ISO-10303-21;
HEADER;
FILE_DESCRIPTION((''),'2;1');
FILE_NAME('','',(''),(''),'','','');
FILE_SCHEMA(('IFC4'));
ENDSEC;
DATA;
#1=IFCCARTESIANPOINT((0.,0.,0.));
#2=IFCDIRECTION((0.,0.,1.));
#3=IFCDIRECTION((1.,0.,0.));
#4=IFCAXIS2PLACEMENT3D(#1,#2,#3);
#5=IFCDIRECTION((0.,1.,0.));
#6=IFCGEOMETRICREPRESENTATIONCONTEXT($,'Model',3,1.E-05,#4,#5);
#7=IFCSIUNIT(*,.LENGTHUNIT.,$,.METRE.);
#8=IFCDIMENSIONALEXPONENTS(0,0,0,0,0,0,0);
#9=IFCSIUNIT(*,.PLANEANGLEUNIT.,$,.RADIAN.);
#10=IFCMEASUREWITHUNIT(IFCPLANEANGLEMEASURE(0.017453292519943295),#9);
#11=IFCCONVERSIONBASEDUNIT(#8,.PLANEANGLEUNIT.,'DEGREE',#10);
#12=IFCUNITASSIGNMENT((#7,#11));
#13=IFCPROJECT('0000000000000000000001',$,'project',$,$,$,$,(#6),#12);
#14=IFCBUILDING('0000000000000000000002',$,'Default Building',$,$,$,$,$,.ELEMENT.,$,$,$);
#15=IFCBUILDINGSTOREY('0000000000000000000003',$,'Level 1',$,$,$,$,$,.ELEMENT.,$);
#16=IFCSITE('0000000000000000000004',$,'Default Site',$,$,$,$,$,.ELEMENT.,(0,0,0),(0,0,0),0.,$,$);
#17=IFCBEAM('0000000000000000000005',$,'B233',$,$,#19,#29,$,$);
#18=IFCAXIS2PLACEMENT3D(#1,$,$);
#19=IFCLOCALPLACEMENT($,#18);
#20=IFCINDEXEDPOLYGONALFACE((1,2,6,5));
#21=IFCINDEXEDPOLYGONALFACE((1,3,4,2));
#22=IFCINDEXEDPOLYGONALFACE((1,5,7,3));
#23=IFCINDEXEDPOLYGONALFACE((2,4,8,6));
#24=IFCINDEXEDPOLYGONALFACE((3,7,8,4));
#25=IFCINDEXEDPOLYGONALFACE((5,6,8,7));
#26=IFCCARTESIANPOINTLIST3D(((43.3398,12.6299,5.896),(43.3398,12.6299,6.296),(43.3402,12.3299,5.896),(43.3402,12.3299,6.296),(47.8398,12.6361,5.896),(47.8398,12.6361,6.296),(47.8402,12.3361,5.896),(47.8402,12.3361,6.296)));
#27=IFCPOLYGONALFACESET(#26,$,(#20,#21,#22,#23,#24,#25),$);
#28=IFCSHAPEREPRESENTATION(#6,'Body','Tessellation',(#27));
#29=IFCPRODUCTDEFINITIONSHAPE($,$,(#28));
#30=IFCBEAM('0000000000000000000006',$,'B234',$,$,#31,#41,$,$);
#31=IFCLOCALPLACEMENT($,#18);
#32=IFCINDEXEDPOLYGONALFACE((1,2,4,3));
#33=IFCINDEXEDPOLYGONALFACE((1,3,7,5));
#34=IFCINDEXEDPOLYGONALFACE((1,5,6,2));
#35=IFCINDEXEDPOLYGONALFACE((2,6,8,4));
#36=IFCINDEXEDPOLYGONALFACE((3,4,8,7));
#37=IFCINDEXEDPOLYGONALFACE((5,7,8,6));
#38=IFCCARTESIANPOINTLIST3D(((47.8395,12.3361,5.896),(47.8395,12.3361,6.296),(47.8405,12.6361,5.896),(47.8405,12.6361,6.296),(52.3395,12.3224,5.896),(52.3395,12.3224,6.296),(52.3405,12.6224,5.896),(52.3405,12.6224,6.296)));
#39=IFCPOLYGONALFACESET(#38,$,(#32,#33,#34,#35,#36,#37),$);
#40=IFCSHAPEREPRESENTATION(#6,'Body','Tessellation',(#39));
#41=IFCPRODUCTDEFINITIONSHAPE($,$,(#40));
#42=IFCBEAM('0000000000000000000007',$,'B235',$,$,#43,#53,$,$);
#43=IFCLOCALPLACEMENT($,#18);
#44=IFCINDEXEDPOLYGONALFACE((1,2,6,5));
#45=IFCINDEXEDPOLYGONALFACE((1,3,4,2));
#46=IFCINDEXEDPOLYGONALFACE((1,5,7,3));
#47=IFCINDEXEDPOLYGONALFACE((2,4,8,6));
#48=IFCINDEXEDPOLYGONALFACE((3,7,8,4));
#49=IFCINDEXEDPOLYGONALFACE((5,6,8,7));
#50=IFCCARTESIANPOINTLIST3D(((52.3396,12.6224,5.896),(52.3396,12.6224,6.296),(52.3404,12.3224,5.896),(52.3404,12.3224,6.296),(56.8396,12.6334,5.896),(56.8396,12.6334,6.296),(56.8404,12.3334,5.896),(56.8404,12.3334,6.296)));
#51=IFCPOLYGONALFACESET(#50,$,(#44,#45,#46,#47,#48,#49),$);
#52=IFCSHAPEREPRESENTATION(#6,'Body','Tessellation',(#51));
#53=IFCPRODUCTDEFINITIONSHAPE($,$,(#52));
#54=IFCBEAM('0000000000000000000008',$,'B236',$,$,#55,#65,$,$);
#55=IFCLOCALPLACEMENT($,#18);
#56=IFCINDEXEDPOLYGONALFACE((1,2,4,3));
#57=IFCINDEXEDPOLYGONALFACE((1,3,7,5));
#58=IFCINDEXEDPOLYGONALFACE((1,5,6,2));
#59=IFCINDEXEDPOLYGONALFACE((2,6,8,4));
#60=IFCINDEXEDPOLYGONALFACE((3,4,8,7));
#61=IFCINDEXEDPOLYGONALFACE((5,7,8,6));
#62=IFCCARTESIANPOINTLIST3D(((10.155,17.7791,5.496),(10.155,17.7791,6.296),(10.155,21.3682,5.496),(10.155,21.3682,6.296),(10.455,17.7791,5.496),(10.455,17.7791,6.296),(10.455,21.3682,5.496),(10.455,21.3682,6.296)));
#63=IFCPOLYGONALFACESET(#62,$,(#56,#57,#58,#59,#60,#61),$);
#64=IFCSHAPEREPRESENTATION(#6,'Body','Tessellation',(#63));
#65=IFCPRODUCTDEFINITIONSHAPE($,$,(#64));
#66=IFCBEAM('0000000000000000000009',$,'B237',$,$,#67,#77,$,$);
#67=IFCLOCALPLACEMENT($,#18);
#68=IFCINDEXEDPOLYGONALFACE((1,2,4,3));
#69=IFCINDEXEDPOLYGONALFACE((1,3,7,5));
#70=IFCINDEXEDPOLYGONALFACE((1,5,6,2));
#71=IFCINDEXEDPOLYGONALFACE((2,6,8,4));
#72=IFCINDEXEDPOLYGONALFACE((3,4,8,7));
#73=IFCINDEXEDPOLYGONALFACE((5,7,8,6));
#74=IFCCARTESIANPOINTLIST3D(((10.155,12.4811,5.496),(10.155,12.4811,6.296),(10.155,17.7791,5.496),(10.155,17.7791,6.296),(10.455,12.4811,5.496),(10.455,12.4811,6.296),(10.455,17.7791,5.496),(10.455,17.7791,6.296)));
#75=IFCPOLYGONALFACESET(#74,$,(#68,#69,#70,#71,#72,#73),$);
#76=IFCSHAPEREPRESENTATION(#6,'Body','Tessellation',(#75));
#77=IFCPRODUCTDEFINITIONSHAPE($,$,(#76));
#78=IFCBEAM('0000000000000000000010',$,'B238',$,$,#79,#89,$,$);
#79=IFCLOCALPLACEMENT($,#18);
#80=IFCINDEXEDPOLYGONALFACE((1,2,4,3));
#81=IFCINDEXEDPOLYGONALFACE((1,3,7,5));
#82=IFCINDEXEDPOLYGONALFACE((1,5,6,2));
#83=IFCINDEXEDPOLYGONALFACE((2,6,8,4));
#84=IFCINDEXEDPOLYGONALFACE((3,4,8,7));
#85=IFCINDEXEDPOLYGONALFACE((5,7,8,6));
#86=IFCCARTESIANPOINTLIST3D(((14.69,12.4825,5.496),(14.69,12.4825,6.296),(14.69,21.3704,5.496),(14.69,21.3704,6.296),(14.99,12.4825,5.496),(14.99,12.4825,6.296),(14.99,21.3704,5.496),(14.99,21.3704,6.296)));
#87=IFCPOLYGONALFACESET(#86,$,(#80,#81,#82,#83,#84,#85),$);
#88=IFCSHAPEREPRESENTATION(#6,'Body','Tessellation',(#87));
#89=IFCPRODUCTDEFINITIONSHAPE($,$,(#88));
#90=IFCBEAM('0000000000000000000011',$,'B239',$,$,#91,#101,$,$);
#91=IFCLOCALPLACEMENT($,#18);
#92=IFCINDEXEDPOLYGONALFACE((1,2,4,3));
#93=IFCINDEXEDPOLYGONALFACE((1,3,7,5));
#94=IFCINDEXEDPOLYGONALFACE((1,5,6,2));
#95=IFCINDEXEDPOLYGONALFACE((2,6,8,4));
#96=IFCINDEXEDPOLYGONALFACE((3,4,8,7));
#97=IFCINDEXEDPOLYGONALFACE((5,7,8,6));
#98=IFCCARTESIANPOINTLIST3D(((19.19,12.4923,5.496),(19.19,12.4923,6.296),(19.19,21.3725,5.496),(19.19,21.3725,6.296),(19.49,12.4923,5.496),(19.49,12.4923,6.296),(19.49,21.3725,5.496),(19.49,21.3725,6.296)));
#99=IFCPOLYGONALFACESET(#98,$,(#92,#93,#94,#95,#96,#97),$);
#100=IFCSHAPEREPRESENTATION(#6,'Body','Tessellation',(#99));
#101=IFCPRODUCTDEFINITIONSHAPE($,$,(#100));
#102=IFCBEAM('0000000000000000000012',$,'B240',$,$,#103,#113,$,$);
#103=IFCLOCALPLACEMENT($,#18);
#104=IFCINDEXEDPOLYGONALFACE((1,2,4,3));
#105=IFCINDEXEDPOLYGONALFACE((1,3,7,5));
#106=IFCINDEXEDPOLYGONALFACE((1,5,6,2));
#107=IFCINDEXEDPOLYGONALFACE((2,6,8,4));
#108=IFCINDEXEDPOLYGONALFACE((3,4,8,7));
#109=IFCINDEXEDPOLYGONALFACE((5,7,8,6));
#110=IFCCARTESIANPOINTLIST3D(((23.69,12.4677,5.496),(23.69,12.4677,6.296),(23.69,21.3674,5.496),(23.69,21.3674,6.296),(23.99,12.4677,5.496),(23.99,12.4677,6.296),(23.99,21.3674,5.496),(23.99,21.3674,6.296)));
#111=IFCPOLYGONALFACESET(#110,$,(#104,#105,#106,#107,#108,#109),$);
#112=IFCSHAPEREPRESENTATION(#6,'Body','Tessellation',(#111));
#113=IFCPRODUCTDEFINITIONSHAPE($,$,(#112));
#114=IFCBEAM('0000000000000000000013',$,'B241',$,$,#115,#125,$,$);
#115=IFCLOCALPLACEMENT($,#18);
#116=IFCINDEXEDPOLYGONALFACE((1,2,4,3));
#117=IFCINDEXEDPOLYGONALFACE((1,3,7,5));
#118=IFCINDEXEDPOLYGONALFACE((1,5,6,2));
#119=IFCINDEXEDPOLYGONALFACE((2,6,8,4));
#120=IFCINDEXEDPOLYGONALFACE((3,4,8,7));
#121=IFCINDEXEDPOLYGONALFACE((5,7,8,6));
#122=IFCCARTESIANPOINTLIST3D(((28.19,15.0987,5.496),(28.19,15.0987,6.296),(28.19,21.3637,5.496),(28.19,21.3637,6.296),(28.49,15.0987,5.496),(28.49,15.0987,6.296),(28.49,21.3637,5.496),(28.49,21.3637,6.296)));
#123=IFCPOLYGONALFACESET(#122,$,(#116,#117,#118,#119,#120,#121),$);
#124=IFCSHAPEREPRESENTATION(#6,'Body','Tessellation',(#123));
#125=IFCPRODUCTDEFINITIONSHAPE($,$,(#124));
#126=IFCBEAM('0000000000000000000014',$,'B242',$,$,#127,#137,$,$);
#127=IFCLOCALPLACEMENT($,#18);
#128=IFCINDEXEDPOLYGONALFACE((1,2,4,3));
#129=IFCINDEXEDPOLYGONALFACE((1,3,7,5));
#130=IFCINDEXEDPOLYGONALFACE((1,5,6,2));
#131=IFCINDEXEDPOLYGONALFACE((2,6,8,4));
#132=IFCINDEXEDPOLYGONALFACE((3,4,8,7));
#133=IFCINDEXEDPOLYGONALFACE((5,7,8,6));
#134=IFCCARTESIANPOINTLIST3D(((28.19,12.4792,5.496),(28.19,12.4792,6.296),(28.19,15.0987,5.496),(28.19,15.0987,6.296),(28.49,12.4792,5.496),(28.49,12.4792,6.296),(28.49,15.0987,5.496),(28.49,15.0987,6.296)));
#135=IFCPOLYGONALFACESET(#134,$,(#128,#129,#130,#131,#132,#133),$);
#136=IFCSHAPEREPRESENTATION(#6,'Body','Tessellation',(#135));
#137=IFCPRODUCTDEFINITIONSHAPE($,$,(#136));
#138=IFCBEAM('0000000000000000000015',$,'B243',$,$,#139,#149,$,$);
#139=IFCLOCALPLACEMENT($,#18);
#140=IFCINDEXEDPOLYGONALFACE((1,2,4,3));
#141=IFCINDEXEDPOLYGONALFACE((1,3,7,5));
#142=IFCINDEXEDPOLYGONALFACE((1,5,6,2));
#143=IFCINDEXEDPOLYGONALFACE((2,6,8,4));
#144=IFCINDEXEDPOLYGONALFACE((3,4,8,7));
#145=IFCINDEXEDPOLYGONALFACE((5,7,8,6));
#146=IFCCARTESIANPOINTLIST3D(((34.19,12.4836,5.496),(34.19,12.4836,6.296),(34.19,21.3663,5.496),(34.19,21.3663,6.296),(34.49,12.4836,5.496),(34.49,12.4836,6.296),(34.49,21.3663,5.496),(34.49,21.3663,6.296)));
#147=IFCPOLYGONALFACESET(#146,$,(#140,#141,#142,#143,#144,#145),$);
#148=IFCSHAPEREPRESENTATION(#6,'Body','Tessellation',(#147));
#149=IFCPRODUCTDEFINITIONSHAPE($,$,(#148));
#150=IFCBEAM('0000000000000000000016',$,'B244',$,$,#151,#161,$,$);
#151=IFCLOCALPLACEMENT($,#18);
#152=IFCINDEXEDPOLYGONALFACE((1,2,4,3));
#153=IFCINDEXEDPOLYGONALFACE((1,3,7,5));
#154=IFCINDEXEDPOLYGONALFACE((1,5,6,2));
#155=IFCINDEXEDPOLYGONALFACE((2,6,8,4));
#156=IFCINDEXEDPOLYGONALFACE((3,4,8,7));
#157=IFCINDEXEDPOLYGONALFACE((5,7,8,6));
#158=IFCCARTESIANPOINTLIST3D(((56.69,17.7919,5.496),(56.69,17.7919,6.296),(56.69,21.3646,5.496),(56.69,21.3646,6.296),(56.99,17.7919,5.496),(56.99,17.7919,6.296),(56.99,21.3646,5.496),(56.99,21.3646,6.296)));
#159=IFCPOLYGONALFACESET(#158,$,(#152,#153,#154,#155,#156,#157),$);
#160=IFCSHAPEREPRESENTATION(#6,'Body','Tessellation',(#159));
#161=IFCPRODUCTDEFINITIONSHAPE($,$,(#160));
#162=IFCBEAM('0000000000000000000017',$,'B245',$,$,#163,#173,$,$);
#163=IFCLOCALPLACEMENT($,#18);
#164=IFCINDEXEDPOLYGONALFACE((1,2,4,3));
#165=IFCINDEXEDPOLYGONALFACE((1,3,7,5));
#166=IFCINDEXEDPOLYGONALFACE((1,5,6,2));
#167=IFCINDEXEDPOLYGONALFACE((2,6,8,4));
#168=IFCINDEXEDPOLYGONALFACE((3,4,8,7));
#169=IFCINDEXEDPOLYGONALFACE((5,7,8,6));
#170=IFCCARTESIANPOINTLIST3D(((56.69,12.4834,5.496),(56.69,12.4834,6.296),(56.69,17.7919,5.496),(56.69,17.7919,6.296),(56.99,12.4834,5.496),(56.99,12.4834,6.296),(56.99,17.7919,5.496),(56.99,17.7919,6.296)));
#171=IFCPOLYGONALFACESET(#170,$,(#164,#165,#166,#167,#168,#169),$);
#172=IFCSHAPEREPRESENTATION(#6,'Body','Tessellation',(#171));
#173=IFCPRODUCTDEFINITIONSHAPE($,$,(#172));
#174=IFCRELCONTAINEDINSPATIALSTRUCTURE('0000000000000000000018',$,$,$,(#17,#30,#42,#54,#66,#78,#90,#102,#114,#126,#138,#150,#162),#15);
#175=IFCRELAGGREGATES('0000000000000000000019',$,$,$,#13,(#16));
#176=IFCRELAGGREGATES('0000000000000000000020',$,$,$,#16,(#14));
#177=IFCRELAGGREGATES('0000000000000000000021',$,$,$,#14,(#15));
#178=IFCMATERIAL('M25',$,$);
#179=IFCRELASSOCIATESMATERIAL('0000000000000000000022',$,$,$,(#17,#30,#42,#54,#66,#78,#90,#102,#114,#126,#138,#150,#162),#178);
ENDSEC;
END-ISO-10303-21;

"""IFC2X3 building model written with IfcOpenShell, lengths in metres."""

from ifc_helpers import new_model, entity, si_unit, converted_unit, direction, frame, frame_2d, origin_with_axes, place, context, project, spatial, rectangle, extrude, material, element, save


model = new_model("IFC2X3")

# Units and contexts
model_context = context("Model", 3, precision=1e-05, world=origin_with_axes(), true_north=direction((0.0, 1.0, 0.0)))
ifc_project = project(units=[si_unit("LENGTHUNIT", "METRE"), converted_unit("PLANEANGLEUNIT", "DEGREE", entity("IfcPlaneAngleMeasure", 0.017453292519943295), si_unit("PLANEANGLEUNIT", "RADIAN"), dimensions=[0, 0, 0, 0, 0, 0, 0])], contexts=[model_context])

# Site, building, storey
site = spatial("IfcSite", under=ifc_project, Name="Default Site", CompositionType="ELEMENT", RefLatitude=(0, 0, 0), RefLongitude=(0, 0, 0), RefElevation=0.0)
building = spatial("IfcBuilding", under=site, Name="Default Building", CompositionType="ELEMENT")
storey = spatial("IfcBuildingStorey", under=building, Name="Level 1", CompositionType="ELEMENT")

# Beams
ifc_material = material(Name="M25")
placement = place(None, origin_with_axes())
element("IfcBeam", 1, at=placement, inside=storey, material=ifc_material, Name="B233", context=model_context, shape_type="SweptSolid", body=[
    extrude(rectangle(XDim=0.3, YDim=0.4, at=frame_2d((0.0, 0.0), x_axis=(0.0, 1.0, 0.0))), frame((43.34, 12.4799, 6.096), z_axis=(0.999999, 0.001374, 0.0), x_axis=(0.0, 0.0, -1.0)), (0.0, 0.0, 1.0), 4.5),
])
element("IfcBeam", 2, at=placement, inside=storey, material=ifc_material, Name="B234", context=model_context, shape_type="SweptSolid", body=[
    extrude(rectangle(XDim=0.3, YDim=0.4, at=frame_2d((0.0, 0.0), x_axis=(0.0, 1.0, 0.0))), frame((47.84, 12.4861, 6.096), z_axis=(0.999995, -0.003045, 0.0), x_axis=(0.0, 0.0, -1.0)), (0.0, 0.0, 1.0), 4.5),
])
element("IfcBeam", 3, at=placement, inside=storey, material=ifc_material, Name="B235", context=model_context, shape_type="SweptSolid", body=[
    extrude(rectangle(XDim=0.3, YDim=0.4, at=frame_2d((0.0, 0.0), x_axis=(0.0, 1.0, 0.0))), frame((52.34, 12.4724, 6.096), z_axis=(0.999997, 0.002456, 0.0), x_axis=(0.0, 0.0, -1.0)), (0.0, 0.0, 1.0), 4.5),
])
element("IfcBeam", 4, at=placement, inside=storey, material=ifc_material, Name="B236", context=model_context, shape_type="SweptSolid", body=[
    extrude(rectangle(XDim=0.3, YDim=0.8, at=frame_2d((0.0, 0.0), x_axis=(0.0, 1.0, 0.0))), frame((10.305, 21.3682, 5.896), z_axis=(0.0, -1.0, 0.0), x_axis=(0.0, 0.0, -1.0)), (0.0, 0.0, 1.0), 3.5891),
])
element("IfcBeam", 5, at=placement, inside=storey, material=ifc_material, Name="B237", context=model_context, shape_type="SweptSolid", body=[
    extrude(rectangle(XDim=0.3, YDim=0.8, at=frame_2d((0.0, 0.0), x_axis=(0.0, 1.0, 0.0))), frame((10.305, 17.7791, 5.896), z_axis=(0.0, -1.0, 0.0), x_axis=(0.0, 0.0, -1.0)), (0.0, 0.0, 1.0), 5.298),
])
element("IfcBeam", 6, at=placement, inside=storey, material=ifc_material, Name="B238", context=model_context, shape_type="SweptSolid", body=[
    extrude(rectangle(XDim=0.3, YDim=0.8, at=frame_2d((0.0, 0.0), x_axis=(0.0, 1.0, 0.0))), frame((14.84, 21.3704, 5.896), z_axis=(0.0, -1.0, 0.0), x_axis=(0.0, 0.0, -1.0)), (0.0, 0.0, 1.0), 8.8879),
])
element("IfcBeam", 7, at=placement, inside=storey, material=ifc_material, Name="B239", context=model_context, shape_type="SweptSolid", body=[
    extrude(rectangle(XDim=0.3, YDim=0.8, at=frame_2d((0.0, 0.0), x_axis=(0.0, 1.0, 0.0))), frame((19.34, 21.3725, 5.896), z_axis=(0.0, -1.0, 0.0), x_axis=(0.0, 0.0, -1.0)), (0.0, 0.0, 1.0), 8.8802),
])
element("IfcBeam", 8, at=placement, inside=storey, material=ifc_material, Name="B240", context=model_context, shape_type="SweptSolid", body=[
    extrude(rectangle(XDim=0.3, YDim=0.8, at=frame_2d((0.0, 0.0), x_axis=(0.0, 1.0, 0.0))), frame((23.84, 21.3674, 5.896), z_axis=(0.0, -1.0, 0.0), x_axis=(0.0, 0.0, -1.0)), (0.0, 0.0, 1.0), 8.8997),
])
element("IfcBeam", 9, at=placement, inside=storey, material=ifc_material, Name="B241", context=model_context, shape_type="SweptSolid", body=[
    extrude(rectangle(XDim=0.3, YDim=0.8, at=frame_2d((0.0, 0.0), x_axis=(0.0, 1.0, 0.0))), frame((28.34, 21.3637, 5.896), z_axis=(0.0, -1.0, 0.0), x_axis=(0.0, 0.0, -1.0)), (0.0, 0.0, 1.0), 6.265),
])
element("IfcBeam", 10, at=placement, inside=storey, material=ifc_material, Name="B242", context=model_context, shape_type="SweptSolid", body=[
    extrude(rectangle(XDim=0.3, YDim=0.8, at=frame_2d((0.0, 0.0), x_axis=(0.0, 1.0, 0.0))), frame((28.34, 15.0987, 5.896), z_axis=(0.0, -1.0, 0.0), x_axis=(0.0, 0.0, -1.0)), (0.0, 0.0, 1.0), 2.6195),
])
element("IfcBeam", 11, at=placement, inside=storey, material=ifc_material, Name="B243", context=model_context, shape_type="SweptSolid", body=[
    extrude(rectangle(XDim=0.3, YDim=0.8, at=frame_2d((0.0, 0.0), x_axis=(0.0, 1.0, 0.0))), frame((34.34, 12.4836, 5.896), z_axis=(0.0, 1.0, 0.0), x_axis=(0.0, 0.0, -1.0)), (0.0, 0.0, 1.0), 8.8827),
])
element("IfcBeam", 12, at=placement, inside=storey, material=ifc_material, Name="B244", context=model_context, shape_type="SweptSolid", body=[
    extrude(rectangle(XDim=0.3, YDim=0.8, at=frame_2d((0.0, 0.0), x_axis=(0.0, 1.0, 0.0))), frame((56.84, 17.7919, 5.896), z_axis=(0.0, 1.0, 0.0), x_axis=(0.0, 0.0, -1.0)), (0.0, 0.0, 1.0), 3.5727),
])
element("IfcBeam", 13, at=placement, inside=storey, material=ifc_material, Name="B245", context=model_context, shape_type="SweptSolid", body=[
    extrude(rectangle(XDim=0.3, YDim=0.8, at=frame_2d((0.0, 0.0), x_axis=(0.0, 1.0, 0.0))), frame((56.84, 12.4834, 5.896), z_axis=(0.0, 1.0, 0.0), x_axis=(0.0, 0.0, -1.0)), (0.0, 0.0, 1.0), 5.3085),
])

save(model, "model.ifc")
